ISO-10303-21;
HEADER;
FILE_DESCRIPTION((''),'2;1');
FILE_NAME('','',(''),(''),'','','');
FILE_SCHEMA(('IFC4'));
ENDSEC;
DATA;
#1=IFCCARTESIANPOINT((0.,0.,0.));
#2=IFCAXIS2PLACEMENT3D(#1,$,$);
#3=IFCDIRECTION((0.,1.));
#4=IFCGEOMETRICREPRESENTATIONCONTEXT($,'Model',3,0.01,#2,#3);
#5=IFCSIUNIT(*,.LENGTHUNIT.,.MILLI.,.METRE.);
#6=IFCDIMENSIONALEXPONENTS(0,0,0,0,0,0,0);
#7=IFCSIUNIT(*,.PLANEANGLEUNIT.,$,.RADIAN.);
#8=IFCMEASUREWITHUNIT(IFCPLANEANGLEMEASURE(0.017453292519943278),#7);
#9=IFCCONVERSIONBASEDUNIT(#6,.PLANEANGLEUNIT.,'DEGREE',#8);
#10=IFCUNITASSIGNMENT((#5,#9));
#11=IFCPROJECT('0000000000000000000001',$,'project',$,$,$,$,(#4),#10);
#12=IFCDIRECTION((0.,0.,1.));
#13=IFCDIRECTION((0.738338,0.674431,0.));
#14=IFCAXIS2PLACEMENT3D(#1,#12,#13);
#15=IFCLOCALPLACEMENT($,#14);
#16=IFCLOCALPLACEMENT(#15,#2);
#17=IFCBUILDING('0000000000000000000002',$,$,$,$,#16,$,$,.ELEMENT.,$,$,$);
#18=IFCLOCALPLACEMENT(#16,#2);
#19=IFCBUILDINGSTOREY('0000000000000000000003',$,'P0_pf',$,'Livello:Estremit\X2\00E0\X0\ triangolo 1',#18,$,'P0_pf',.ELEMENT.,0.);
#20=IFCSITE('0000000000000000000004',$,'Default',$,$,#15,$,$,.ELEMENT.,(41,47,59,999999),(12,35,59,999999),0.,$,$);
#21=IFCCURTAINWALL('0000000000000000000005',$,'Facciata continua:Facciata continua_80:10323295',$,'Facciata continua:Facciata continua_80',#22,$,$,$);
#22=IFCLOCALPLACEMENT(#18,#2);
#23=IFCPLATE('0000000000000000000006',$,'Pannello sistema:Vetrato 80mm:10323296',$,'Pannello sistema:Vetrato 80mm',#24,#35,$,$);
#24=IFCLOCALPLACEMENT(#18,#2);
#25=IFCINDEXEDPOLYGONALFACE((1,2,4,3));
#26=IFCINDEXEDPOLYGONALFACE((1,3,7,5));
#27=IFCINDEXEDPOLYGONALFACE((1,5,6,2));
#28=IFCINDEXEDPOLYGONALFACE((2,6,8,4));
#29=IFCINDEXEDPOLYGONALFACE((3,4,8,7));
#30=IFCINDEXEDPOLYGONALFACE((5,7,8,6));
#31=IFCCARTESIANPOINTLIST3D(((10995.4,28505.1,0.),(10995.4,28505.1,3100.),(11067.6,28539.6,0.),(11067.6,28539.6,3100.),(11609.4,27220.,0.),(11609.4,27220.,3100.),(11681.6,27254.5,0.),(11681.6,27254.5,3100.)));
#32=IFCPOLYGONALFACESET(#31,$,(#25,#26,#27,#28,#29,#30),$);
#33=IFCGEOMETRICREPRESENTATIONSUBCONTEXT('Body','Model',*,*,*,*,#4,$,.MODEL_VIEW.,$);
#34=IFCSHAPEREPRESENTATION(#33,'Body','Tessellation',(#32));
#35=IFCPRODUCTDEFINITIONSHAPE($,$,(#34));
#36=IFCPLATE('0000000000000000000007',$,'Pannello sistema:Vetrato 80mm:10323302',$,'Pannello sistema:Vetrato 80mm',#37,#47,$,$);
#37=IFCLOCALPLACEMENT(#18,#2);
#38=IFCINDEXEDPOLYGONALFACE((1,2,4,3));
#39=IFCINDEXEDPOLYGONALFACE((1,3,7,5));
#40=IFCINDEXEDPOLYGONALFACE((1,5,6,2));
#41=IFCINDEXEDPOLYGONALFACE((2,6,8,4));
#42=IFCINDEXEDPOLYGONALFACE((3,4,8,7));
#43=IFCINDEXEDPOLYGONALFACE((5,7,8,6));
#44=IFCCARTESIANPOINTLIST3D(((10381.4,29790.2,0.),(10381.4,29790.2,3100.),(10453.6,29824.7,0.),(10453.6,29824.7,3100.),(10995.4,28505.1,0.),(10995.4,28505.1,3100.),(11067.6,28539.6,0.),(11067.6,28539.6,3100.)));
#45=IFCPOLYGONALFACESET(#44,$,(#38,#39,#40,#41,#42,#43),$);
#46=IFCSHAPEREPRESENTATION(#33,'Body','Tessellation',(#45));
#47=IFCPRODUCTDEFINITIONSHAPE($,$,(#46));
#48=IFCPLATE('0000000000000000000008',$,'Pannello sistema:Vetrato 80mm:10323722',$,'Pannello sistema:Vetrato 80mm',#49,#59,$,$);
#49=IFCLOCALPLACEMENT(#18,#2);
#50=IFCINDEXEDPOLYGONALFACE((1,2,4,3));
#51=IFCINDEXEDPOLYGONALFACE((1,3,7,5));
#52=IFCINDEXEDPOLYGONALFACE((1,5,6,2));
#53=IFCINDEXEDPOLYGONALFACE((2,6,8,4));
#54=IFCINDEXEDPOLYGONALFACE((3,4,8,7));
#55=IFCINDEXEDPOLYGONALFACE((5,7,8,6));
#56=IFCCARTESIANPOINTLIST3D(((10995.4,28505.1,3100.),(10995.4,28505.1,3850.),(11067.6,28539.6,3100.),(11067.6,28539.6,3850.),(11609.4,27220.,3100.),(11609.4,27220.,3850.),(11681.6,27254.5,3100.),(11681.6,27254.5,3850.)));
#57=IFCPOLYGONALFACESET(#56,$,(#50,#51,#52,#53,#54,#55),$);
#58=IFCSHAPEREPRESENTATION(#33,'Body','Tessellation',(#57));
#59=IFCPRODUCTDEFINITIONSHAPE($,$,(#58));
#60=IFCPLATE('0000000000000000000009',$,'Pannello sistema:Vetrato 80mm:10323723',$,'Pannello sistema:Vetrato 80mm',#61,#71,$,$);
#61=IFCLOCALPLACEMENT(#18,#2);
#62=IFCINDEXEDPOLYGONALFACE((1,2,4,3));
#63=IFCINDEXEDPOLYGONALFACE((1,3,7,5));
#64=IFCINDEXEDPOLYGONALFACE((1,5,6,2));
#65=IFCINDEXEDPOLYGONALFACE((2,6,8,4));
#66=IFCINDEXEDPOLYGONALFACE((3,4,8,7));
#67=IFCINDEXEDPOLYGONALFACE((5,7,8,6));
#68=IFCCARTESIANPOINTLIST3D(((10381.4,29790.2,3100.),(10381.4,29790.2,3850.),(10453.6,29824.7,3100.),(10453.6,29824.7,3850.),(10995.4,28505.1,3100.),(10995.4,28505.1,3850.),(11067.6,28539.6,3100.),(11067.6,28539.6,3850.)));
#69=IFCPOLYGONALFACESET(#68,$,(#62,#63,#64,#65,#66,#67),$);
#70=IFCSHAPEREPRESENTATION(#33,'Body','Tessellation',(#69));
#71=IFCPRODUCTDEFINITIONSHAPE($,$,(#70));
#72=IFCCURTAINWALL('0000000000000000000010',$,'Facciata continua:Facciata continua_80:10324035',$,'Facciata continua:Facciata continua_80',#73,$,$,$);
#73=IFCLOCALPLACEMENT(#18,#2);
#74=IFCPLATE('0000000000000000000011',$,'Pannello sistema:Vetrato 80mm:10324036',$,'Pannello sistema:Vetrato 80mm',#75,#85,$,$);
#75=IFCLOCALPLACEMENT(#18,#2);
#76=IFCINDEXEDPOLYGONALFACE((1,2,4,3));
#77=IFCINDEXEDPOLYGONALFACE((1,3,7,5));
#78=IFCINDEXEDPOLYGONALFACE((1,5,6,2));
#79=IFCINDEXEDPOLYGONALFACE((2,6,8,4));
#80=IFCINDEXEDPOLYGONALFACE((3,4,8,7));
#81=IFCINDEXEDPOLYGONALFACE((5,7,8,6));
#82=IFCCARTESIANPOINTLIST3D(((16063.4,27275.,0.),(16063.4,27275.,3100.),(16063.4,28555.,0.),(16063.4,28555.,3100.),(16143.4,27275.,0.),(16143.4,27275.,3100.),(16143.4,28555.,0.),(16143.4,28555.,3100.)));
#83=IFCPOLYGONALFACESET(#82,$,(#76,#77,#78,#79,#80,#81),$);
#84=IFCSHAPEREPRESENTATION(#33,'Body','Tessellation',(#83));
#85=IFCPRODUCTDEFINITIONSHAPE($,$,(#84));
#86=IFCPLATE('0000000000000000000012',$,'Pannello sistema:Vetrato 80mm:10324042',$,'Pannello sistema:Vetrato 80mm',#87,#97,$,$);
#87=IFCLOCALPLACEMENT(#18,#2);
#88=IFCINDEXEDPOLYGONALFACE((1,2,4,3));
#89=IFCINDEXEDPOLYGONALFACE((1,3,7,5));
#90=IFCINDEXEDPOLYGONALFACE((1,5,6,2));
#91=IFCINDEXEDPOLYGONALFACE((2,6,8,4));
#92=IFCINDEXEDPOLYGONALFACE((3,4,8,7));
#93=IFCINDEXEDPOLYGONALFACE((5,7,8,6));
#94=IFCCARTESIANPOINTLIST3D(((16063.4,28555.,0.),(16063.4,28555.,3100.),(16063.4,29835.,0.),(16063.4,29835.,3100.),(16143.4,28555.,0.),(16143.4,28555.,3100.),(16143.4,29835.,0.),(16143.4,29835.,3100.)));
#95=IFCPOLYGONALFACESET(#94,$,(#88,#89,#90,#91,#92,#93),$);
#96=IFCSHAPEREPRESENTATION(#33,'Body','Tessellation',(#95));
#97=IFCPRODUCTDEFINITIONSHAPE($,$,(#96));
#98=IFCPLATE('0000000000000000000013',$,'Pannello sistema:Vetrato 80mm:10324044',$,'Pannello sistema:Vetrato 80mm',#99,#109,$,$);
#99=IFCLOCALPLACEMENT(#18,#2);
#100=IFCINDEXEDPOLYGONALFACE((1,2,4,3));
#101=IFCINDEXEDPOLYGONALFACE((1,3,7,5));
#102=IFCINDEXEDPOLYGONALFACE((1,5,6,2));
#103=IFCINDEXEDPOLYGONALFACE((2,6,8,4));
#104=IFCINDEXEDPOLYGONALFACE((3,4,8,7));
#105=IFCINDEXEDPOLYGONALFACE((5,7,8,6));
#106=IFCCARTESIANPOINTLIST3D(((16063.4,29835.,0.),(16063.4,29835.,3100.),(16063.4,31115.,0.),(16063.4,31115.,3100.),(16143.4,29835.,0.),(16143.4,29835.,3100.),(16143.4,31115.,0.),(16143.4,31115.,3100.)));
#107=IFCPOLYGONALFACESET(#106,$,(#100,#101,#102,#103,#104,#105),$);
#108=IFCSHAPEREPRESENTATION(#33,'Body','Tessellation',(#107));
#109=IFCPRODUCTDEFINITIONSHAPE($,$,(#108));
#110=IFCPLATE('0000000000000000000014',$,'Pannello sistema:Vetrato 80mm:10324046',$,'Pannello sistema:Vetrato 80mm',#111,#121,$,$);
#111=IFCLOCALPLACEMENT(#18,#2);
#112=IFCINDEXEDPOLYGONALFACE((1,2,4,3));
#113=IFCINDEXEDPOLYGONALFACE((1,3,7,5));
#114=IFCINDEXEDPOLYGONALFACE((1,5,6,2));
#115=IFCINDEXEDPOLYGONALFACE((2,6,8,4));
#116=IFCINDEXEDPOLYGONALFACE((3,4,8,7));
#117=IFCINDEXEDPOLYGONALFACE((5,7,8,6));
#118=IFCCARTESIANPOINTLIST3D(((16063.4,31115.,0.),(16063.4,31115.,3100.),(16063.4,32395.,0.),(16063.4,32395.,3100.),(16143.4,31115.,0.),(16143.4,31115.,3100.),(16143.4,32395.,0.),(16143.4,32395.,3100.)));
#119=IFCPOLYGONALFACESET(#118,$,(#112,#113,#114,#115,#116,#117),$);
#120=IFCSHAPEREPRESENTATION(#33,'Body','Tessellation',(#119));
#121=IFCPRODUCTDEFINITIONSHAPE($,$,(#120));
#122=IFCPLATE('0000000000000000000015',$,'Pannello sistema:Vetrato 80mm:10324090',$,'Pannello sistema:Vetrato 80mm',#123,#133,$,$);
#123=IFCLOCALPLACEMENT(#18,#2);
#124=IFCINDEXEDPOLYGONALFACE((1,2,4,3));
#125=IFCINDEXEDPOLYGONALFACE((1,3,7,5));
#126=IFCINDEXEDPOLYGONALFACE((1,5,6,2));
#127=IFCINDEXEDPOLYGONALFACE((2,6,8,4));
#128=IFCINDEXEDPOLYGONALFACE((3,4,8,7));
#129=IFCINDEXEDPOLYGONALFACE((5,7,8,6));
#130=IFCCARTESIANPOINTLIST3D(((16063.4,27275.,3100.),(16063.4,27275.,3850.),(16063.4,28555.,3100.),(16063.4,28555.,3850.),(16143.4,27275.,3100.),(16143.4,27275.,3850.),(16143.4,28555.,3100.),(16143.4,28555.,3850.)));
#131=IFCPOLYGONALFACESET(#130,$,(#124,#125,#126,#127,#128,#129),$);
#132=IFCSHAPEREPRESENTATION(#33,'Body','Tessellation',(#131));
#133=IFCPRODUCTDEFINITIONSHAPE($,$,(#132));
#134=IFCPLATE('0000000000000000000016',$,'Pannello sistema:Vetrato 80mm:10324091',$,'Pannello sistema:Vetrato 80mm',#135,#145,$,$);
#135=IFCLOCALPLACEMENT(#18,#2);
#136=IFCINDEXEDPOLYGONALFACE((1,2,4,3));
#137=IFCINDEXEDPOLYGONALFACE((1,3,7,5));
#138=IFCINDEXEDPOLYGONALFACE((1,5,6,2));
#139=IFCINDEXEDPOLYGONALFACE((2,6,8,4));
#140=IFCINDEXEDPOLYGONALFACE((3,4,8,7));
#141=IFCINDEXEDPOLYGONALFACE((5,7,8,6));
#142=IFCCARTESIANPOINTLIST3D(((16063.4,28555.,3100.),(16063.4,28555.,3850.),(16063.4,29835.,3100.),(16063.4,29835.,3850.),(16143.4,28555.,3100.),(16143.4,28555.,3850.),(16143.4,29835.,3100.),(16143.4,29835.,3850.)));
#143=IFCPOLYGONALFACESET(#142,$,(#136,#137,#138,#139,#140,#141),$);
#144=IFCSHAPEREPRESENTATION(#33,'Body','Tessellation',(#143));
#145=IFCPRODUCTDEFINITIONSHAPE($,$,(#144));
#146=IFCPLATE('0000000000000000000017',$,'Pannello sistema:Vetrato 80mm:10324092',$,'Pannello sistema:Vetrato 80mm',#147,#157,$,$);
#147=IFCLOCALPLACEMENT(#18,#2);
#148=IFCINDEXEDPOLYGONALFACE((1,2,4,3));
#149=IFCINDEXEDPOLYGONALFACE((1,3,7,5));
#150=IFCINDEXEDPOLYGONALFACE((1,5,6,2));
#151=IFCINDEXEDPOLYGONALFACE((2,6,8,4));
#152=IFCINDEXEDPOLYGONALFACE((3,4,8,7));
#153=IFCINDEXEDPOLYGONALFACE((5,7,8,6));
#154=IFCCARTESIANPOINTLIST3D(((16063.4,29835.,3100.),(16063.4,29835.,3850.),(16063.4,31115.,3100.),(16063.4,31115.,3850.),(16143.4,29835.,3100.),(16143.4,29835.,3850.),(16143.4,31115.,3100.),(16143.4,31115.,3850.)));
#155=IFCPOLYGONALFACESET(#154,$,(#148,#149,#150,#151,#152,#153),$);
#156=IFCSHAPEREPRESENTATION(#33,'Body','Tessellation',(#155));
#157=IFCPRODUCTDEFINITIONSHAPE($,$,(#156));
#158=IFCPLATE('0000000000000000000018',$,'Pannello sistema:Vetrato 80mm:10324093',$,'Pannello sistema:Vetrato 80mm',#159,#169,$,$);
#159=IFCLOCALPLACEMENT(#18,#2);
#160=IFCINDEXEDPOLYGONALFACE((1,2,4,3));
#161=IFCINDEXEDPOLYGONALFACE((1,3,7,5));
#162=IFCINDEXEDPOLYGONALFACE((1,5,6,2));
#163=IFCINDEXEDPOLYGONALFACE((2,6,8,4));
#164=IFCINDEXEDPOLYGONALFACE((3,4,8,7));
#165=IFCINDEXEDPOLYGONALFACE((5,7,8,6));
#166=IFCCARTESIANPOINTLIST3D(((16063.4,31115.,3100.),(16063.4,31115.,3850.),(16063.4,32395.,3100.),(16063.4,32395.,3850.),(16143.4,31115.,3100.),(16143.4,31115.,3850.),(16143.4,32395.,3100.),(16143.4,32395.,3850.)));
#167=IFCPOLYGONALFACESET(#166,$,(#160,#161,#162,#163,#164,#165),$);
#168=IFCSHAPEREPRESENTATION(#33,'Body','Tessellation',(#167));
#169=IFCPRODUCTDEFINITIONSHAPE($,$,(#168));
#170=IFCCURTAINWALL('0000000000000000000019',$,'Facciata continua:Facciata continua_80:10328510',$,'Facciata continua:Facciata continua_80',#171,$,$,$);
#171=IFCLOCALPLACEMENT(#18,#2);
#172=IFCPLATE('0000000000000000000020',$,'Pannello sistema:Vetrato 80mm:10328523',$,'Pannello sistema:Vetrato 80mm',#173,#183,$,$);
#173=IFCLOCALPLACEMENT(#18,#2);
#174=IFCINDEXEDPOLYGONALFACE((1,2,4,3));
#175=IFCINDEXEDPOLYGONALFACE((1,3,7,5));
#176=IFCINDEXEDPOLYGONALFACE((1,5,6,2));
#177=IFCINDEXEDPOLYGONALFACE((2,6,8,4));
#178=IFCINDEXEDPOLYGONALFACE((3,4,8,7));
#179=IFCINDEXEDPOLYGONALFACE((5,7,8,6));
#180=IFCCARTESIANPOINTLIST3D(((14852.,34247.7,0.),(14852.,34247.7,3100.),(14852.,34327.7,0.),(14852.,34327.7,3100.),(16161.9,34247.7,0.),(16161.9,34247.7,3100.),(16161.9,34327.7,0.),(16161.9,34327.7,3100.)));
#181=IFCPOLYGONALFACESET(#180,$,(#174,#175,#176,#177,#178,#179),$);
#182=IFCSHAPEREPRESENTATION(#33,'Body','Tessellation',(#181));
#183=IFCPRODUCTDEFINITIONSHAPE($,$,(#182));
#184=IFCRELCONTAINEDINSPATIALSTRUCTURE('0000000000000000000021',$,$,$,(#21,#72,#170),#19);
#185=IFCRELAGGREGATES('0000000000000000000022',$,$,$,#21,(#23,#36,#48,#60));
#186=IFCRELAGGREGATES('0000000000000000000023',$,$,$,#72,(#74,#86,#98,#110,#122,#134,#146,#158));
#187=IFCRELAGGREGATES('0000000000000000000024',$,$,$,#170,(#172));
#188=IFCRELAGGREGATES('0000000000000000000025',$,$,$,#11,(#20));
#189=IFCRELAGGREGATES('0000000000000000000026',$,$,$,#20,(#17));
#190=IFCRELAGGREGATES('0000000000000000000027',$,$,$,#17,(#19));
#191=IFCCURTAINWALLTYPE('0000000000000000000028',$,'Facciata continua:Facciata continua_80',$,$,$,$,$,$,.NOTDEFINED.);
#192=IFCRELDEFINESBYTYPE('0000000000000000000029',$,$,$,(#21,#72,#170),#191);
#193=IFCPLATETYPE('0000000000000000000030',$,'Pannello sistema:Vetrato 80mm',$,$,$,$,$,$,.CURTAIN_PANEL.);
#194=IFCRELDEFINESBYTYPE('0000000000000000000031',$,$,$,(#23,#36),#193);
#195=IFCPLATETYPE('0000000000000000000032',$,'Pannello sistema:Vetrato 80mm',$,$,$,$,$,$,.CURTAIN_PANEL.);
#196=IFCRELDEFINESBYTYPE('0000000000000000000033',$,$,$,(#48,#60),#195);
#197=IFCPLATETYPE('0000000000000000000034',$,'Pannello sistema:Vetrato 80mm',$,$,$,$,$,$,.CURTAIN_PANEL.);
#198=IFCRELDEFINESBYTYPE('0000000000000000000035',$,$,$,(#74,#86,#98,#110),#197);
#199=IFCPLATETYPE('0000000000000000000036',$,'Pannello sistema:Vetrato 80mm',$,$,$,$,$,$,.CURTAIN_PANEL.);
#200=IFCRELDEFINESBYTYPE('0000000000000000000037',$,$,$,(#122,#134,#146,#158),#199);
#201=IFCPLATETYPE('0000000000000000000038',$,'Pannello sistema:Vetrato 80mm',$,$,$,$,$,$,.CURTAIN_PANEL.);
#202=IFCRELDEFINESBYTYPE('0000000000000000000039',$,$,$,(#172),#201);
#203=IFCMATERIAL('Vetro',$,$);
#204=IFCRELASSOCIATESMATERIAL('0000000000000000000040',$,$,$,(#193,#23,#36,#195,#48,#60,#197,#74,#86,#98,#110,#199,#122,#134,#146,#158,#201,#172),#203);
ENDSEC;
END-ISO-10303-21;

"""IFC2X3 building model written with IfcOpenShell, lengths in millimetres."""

from ifc_helpers import new_model, entity, si_unit, converted_unit, direction, frame, frame_2d, origin, origin_2d_with_axis, place, context, subcontext, project, spatial, rectangle, extrude, source, transform, mapped, material, type_object, type_shapes, element, aggregate, save


model = new_model("IFC2X3")

# Units and contexts
model_context = context("Model", 3, precision=0.01, world=origin(), true_north=direction((0.0, 1.0)))
body_context = subcontext(model_context, "Body", "Model", "MODEL_VIEW")
ifc_project = project(units=[si_unit("LENGTHUNIT", "METRE", prefix="MILLI"), converted_unit("PLANEANGLEUNIT", "DEGREE", entity("IfcPlaneAngleMeasure", 0.017453292519943278), si_unit("PLANEANGLEUNIT", "RADIAN"), dimensions=[0, 0, 0, 0, 0, 0, 0])], contexts=[model_context])

# Site, building, storey
site_placement = place(None, frame((0.0, 0.0, 0.0), z_axis=(0.0, 0.0, 1.0), x_axis=(0.738338, 0.674431, 0.0)))
site = spatial("IfcSite", under=ifc_project, at=site_placement, Name="Default", CompositionType="ELEMENT", RefLatitude=(41, 47, 59, 999999), RefLongitude=(12, 35, 59, 999999), RefElevation=0.0)
building_placement = place(site_placement, origin())
building = spatial("IfcBuilding", under=site, at=building_placement, CompositionType="ELEMENT")
storey_placement = place(building_placement, origin())
storey = spatial("IfcBuildingStorey", under=building, at=storey_placement, Name="P0_pf", ObjectType="Livello:Estremità triangolo 1", LongName="P0_pf", CompositionType="ELEMENT", Elevation=0.0)

# Curtain walls, plates
curtain_wall_type = type_object("IfcCurtainWallType", Name="Facciata continua:Facciata continua_80", PredefinedType="NOTDEFINED")
curtain_wall_1_placement = place(storey_placement, origin())
curtain_wall_1 = element("IfcCurtainWall", 1, at=curtain_wall_1_placement, inside=storey, type_object=curtain_wall_type, Name="Facciata continua:Facciata continua_80:10323295", ObjectType="Facciata continua:Facciata continua_80")
ifc_material_1 = material(Name="Vetro")
plate_type_1 = type_object("IfcPlateType", Name="Pannello sistema:Vetrato 80mm", PredefinedType="CURTAIN_PANEL", material=ifc_material_1)
shared_shape_1 = source(origin(), body_context, "Body", "SweptSolid", [
    extrude(rectangle(XDim=80.0, YDim=1424.3, at=frame_2d((0.0, 0.0), x_axis=(1.0, 0.0))), frame((0.0, -40.0, 0.0), z_axis=(0.0, 0.0, 1.0), x_axis=(0.0, 1.0, 0.0)), (0.0, 0.0, 1.0), 3100.0),
])
type_shapes(plate_type_1, [shared_shape_1])
plate_1_placement = place(curtain_wall_1_placement, frame((11302.4, 27862.6, 0.0), z_axis=(0.0, 0.0, 1.0), x_axis=(-0.431105, 0.902302, 0.0)))
plate_1 = element("IfcPlate", 2, at=plate_1_placement, type_object=plate_type_1, material=ifc_material_1, Name="Pannello sistema:Vetrato 80mm:10323296", ObjectType="Pannello sistema:Vetrato 80mm", context=body_context, shape_type="MappedRepresentation", body=[
    mapped(shared_shape_1, transform((0.0, 0.0, 0.0), scale=1.0)),
])
plate_2_placement = place(curtain_wall_1_placement, frame((10688.4, 29147.7, 0.0), z_axis=(0.0, 0.0, 1.0), x_axis=(-0.431105, 0.902302, 0.0)))
plate_2 = element("IfcPlate", 3, at=plate_2_placement, type_object=plate_type_1, material=ifc_material_1, Name="Pannello sistema:Vetrato 80mm:10323302", ObjectType="Pannello sistema:Vetrato 80mm", context=body_context, shape_type="MappedRepresentation", body=[
    mapped(shared_shape_1, transform((0.0, 0.0, 0.0), scale=1.0)),
])
plate_type_2 = type_object("IfcPlateType", Name="Pannello sistema:Vetrato 80mm", PredefinedType="CURTAIN_PANEL", material=ifc_material_1)
shared_shape_2 = source(origin(), body_context, "Body", "SweptSolid", [
    extrude(rectangle(XDim=80.0, YDim=1424.3, at=frame_2d((0.0, 0.0), x_axis=(1.0, 0.0))), frame((0.0, -40.0, 0.0), z_axis=(0.0, 0.0, 1.0), x_axis=(0.0, 1.0, 0.0)), (0.0, 0.0, 1.0), 750.0),
])
type_shapes(plate_type_2, [shared_shape_2])
plate_3_placement = place(curtain_wall_1_placement, frame((11302.4, 27862.6, 3100.0), z_axis=(0.0, 0.0, 1.0), x_axis=(-0.431105, 0.902302, 0.0)))
plate_3 = element("IfcPlate", 4, at=plate_3_placement, type_object=plate_type_2, material=ifc_material_1, Name="Pannello sistema:Vetrato 80mm:10323722", ObjectType="Pannello sistema:Vetrato 80mm", context=body_context, shape_type="MappedRepresentation", body=[
    mapped(shared_shape_2, transform((0.0, 0.0, 0.0), scale=1.0)),
])
plate_4_placement = place(curtain_wall_1_placement, frame((10688.4, 29147.7, 3100.0), z_axis=(0.0, 0.0, 1.0), x_axis=(-0.431105, 0.902302, 0.0)))
plate_4 = element("IfcPlate", 5, at=plate_4_placement, type_object=plate_type_2, material=ifc_material_1, Name="Pannello sistema:Vetrato 80mm:10323723", ObjectType="Pannello sistema:Vetrato 80mm", context=body_context, shape_type="MappedRepresentation", body=[
    mapped(shared_shape_2, transform((0.0, 0.0, 0.0), scale=1.0)),
])
aggregate(curtain_wall_1, [plate_1, plate_2, plate_3, plate_4])
curtain_wall_2_placement = place(storey_placement, origin())
curtain_wall_2 = element("IfcCurtainWall", 6, at=curtain_wall_2_placement, inside=storey, type_object=curtain_wall_type, Name="Facciata continua:Facciata continua_80:10324035", ObjectType="Facciata continua:Facciata continua_80")
plate_type_3 = type_object("IfcPlateType", Name="Pannello sistema:Vetrato 80mm", PredefinedType="CURTAIN_PANEL", material=ifc_material_1)
shared_shape_3 = source(origin(), body_context, "Body", "SweptSolid", [
    extrude(rectangle(XDim=80.0, YDim=1280.0, at=origin_2d_with_axis()), frame((0.0, -40.0, 0.0), z_axis=(0.0, 0.0, 1.0), x_axis=(0.0, 1.0, 0.0)), (0.0, 0.0, 1.0), 3100.0),
])
type_shapes(plate_type_3, [shared_shape_3])
plate_5_placement = place(curtain_wall_2_placement, frame((16063.4, 27915.0, 0.0), z_axis=(0.0, 0.0, 1.0), x_axis=(0.0, 1.0, 0.0)))
plate_5 = element("IfcPlate", 7, at=plate_5_placement, type_object=plate_type_3, material=ifc_material_1, Name="Pannello sistema:Vetrato 80mm:10324036", ObjectType="Pannello sistema:Vetrato 80mm", context=body_context, shape_type="MappedRepresentation", body=[
    mapped(shared_shape_3, transform((0.0, 0.0, 0.0), scale=1.0)),
])
plate_6_placement = place(curtain_wall_2_placement, frame((16063.4, 29195.0, 0.0), z_axis=(0.0, 0.0, 1.0), x_axis=(0.0, 1.0, 0.0)))
plate_6 = element("IfcPlate", 8, at=plate_6_placement, type_object=plate_type_3, material=ifc_material_1, Name="Pannello sistema:Vetrato 80mm:10324042", ObjectType="Pannello sistema:Vetrato 80mm", context=body_context, shape_type="MappedRepresentation", body=[
    mapped(shared_shape_3, transform((0.0, 0.0, 0.0), scale=1.0)),
])
plate_7_placement = place(curtain_wall_2_placement, frame((16063.4, 30475.0, 0.0), z_axis=(0.0, 0.0, 1.0), x_axis=(0.0, 1.0, 0.0)))
plate_7 = element("IfcPlate", 9, at=plate_7_placement, type_object=plate_type_3, material=ifc_material_1, Name="Pannello sistema:Vetrato 80mm:10324044", ObjectType="Pannello sistema:Vetrato 80mm", context=body_context, shape_type="MappedRepresentation", body=[
    mapped(shared_shape_3, transform((0.0, 0.0, 0.0), scale=1.0)),
])
plate_8_placement = place(curtain_wall_2_placement, frame((16063.4, 31755.0, 0.0), z_axis=(0.0, 0.0, 1.0), x_axis=(0.0, 1.0, 0.0)))
plate_8 = element("IfcPlate", 10, at=plate_8_placement, type_object=plate_type_3, material=ifc_material_1, Name="Pannello sistema:Vetrato 80mm:10324046", ObjectType="Pannello sistema:Vetrato 80mm", context=body_context, shape_type="MappedRepresentation", body=[
    mapped(shared_shape_3, transform((0.0, 0.0, 0.0), scale=1.0)),
])
plate_type_4 = type_object("IfcPlateType", Name="Pannello sistema:Vetrato 80mm", PredefinedType="CURTAIN_PANEL", material=ifc_material_1)
shared_shape_4 = source(origin(), body_context, "Body", "SweptSolid", [
    extrude(rectangle(XDim=80.0, YDim=1280.0, at=origin_2d_with_axis()), frame((0.0, -40.0, 0.0), z_axis=(0.0, 0.0, 1.0), x_axis=(0.0, 1.0, 0.0)), (0.0, 0.0, 1.0), 750.0),
])
type_shapes(plate_type_4, [shared_shape_4])
plate_9_placement = place(curtain_wall_2_placement, frame((16063.4, 27915.0, 3100.0), z_axis=(0.0, 0.0, 1.0), x_axis=(0.0, 1.0, 0.0)))
plate_9 = element("IfcPlate", 11, at=plate_9_placement, type_object=plate_type_4, material=ifc_material_1, Name="Pannello sistema:Vetrato 80mm:10324090", ObjectType="Pannello sistema:Vetrato 80mm", context=body_context, shape_type="MappedRepresentation", body=[
    mapped(shared_shape_4, transform((0.0, 0.0, 0.0), scale=1.0)),
])
plate_10_placement = place(curtain_wall_2_placement, frame((16063.4, 29195.0, 3100.0), z_axis=(0.0, 0.0, 1.0), x_axis=(0.0, 1.0, 0.0)))
plate_10 = element("IfcPlate", 12, at=plate_10_placement, type_object=plate_type_4, material=ifc_material_1, Name="Pannello sistema:Vetrato 80mm:10324091", ObjectType="Pannello sistema:Vetrato 80mm", context=body_context, shape_type="MappedRepresentation", body=[
    mapped(shared_shape_4, transform((0.0, 0.0, 0.0), scale=1.0)),
])
plate_11_placement = place(curtain_wall_2_placement, frame((16063.4, 30475.0, 3100.0), z_axis=(0.0, 0.0, 1.0), x_axis=(0.0, 1.0, 0.0)))
plate_11 = element("IfcPlate", 13, at=plate_11_placement, type_object=plate_type_4, material=ifc_material_1, Name="Pannello sistema:Vetrato 80mm:10324092", ObjectType="Pannello sistema:Vetrato 80mm", context=body_context, shape_type="MappedRepresentation", body=[
    mapped(shared_shape_4, transform((0.0, 0.0, 0.0), scale=1.0)),
])
plate_12_placement = place(curtain_wall_2_placement, frame((16063.4, 31755.0, 3100.0), z_axis=(0.0, 0.0, 1.0), x_axis=(0.0, 1.0, 0.0)))
plate_12 = element("IfcPlate", 14, at=plate_12_placement, type_object=plate_type_4, material=ifc_material_1, Name="Pannello sistema:Vetrato 80mm:10324093", ObjectType="Pannello sistema:Vetrato 80mm", context=body_context, shape_type="MappedRepresentation", body=[
    mapped(shared_shape_4, transform((0.0, 0.0, 0.0), scale=1.0)),
])
aggregate(curtain_wall_2, [plate_5, plate_6, plate_7, plate_8, plate_9, plate_10, plate_11, plate_12])
curtain_wall_3_placement = place(storey_placement, origin())
curtain_wall_3 = element("IfcCurtainWall", 15, at=curtain_wall_3_placement, inside=storey, type_object=curtain_wall_type, Name="Facciata continua:Facciata continua_80:10328510", ObjectType="Facciata continua:Facciata continua_80")
plate_type_5 = type_object("IfcPlateType", Name="Pannello sistema:Vetrato 80mm", PredefinedType="CURTAIN_PANEL", material=ifc_material_1)
shared_shape_5 = source(origin(), body_context, "Body", "SweptSolid", [
    extrude(rectangle(XDim=80.0, YDim=1309.8, at=origin_2d_with_axis()), frame((0.0, -40.0, 0.0), z_axis=(0.0, 0.0, 1.0), x_axis=(0.0, 1.0, 0.0)), (0.0, 0.0, 1.0), 3100.0),
])
type_shapes(plate_type_5, [shared_shape_5])
plate_13_placement = place(curtain_wall_3_placement, frame((15506.9, 34327.7, 0.0)))
plate_13 = element("IfcPlate", 16, at=plate_13_placement, type_object=plate_type_5, material=ifc_material_1, Name="Pannello sistema:Vetrato 80mm:10328523", ObjectType="Pannello sistema:Vetrato 80mm", context=body_context, shape_type="MappedRepresentation", body=[
    mapped(shared_shape_5, transform((0.0, 0.0, 0.0), scale=1.0)),
])
aggregate(curtain_wall_3, [plate_13])

save(model, "model.ifc")
